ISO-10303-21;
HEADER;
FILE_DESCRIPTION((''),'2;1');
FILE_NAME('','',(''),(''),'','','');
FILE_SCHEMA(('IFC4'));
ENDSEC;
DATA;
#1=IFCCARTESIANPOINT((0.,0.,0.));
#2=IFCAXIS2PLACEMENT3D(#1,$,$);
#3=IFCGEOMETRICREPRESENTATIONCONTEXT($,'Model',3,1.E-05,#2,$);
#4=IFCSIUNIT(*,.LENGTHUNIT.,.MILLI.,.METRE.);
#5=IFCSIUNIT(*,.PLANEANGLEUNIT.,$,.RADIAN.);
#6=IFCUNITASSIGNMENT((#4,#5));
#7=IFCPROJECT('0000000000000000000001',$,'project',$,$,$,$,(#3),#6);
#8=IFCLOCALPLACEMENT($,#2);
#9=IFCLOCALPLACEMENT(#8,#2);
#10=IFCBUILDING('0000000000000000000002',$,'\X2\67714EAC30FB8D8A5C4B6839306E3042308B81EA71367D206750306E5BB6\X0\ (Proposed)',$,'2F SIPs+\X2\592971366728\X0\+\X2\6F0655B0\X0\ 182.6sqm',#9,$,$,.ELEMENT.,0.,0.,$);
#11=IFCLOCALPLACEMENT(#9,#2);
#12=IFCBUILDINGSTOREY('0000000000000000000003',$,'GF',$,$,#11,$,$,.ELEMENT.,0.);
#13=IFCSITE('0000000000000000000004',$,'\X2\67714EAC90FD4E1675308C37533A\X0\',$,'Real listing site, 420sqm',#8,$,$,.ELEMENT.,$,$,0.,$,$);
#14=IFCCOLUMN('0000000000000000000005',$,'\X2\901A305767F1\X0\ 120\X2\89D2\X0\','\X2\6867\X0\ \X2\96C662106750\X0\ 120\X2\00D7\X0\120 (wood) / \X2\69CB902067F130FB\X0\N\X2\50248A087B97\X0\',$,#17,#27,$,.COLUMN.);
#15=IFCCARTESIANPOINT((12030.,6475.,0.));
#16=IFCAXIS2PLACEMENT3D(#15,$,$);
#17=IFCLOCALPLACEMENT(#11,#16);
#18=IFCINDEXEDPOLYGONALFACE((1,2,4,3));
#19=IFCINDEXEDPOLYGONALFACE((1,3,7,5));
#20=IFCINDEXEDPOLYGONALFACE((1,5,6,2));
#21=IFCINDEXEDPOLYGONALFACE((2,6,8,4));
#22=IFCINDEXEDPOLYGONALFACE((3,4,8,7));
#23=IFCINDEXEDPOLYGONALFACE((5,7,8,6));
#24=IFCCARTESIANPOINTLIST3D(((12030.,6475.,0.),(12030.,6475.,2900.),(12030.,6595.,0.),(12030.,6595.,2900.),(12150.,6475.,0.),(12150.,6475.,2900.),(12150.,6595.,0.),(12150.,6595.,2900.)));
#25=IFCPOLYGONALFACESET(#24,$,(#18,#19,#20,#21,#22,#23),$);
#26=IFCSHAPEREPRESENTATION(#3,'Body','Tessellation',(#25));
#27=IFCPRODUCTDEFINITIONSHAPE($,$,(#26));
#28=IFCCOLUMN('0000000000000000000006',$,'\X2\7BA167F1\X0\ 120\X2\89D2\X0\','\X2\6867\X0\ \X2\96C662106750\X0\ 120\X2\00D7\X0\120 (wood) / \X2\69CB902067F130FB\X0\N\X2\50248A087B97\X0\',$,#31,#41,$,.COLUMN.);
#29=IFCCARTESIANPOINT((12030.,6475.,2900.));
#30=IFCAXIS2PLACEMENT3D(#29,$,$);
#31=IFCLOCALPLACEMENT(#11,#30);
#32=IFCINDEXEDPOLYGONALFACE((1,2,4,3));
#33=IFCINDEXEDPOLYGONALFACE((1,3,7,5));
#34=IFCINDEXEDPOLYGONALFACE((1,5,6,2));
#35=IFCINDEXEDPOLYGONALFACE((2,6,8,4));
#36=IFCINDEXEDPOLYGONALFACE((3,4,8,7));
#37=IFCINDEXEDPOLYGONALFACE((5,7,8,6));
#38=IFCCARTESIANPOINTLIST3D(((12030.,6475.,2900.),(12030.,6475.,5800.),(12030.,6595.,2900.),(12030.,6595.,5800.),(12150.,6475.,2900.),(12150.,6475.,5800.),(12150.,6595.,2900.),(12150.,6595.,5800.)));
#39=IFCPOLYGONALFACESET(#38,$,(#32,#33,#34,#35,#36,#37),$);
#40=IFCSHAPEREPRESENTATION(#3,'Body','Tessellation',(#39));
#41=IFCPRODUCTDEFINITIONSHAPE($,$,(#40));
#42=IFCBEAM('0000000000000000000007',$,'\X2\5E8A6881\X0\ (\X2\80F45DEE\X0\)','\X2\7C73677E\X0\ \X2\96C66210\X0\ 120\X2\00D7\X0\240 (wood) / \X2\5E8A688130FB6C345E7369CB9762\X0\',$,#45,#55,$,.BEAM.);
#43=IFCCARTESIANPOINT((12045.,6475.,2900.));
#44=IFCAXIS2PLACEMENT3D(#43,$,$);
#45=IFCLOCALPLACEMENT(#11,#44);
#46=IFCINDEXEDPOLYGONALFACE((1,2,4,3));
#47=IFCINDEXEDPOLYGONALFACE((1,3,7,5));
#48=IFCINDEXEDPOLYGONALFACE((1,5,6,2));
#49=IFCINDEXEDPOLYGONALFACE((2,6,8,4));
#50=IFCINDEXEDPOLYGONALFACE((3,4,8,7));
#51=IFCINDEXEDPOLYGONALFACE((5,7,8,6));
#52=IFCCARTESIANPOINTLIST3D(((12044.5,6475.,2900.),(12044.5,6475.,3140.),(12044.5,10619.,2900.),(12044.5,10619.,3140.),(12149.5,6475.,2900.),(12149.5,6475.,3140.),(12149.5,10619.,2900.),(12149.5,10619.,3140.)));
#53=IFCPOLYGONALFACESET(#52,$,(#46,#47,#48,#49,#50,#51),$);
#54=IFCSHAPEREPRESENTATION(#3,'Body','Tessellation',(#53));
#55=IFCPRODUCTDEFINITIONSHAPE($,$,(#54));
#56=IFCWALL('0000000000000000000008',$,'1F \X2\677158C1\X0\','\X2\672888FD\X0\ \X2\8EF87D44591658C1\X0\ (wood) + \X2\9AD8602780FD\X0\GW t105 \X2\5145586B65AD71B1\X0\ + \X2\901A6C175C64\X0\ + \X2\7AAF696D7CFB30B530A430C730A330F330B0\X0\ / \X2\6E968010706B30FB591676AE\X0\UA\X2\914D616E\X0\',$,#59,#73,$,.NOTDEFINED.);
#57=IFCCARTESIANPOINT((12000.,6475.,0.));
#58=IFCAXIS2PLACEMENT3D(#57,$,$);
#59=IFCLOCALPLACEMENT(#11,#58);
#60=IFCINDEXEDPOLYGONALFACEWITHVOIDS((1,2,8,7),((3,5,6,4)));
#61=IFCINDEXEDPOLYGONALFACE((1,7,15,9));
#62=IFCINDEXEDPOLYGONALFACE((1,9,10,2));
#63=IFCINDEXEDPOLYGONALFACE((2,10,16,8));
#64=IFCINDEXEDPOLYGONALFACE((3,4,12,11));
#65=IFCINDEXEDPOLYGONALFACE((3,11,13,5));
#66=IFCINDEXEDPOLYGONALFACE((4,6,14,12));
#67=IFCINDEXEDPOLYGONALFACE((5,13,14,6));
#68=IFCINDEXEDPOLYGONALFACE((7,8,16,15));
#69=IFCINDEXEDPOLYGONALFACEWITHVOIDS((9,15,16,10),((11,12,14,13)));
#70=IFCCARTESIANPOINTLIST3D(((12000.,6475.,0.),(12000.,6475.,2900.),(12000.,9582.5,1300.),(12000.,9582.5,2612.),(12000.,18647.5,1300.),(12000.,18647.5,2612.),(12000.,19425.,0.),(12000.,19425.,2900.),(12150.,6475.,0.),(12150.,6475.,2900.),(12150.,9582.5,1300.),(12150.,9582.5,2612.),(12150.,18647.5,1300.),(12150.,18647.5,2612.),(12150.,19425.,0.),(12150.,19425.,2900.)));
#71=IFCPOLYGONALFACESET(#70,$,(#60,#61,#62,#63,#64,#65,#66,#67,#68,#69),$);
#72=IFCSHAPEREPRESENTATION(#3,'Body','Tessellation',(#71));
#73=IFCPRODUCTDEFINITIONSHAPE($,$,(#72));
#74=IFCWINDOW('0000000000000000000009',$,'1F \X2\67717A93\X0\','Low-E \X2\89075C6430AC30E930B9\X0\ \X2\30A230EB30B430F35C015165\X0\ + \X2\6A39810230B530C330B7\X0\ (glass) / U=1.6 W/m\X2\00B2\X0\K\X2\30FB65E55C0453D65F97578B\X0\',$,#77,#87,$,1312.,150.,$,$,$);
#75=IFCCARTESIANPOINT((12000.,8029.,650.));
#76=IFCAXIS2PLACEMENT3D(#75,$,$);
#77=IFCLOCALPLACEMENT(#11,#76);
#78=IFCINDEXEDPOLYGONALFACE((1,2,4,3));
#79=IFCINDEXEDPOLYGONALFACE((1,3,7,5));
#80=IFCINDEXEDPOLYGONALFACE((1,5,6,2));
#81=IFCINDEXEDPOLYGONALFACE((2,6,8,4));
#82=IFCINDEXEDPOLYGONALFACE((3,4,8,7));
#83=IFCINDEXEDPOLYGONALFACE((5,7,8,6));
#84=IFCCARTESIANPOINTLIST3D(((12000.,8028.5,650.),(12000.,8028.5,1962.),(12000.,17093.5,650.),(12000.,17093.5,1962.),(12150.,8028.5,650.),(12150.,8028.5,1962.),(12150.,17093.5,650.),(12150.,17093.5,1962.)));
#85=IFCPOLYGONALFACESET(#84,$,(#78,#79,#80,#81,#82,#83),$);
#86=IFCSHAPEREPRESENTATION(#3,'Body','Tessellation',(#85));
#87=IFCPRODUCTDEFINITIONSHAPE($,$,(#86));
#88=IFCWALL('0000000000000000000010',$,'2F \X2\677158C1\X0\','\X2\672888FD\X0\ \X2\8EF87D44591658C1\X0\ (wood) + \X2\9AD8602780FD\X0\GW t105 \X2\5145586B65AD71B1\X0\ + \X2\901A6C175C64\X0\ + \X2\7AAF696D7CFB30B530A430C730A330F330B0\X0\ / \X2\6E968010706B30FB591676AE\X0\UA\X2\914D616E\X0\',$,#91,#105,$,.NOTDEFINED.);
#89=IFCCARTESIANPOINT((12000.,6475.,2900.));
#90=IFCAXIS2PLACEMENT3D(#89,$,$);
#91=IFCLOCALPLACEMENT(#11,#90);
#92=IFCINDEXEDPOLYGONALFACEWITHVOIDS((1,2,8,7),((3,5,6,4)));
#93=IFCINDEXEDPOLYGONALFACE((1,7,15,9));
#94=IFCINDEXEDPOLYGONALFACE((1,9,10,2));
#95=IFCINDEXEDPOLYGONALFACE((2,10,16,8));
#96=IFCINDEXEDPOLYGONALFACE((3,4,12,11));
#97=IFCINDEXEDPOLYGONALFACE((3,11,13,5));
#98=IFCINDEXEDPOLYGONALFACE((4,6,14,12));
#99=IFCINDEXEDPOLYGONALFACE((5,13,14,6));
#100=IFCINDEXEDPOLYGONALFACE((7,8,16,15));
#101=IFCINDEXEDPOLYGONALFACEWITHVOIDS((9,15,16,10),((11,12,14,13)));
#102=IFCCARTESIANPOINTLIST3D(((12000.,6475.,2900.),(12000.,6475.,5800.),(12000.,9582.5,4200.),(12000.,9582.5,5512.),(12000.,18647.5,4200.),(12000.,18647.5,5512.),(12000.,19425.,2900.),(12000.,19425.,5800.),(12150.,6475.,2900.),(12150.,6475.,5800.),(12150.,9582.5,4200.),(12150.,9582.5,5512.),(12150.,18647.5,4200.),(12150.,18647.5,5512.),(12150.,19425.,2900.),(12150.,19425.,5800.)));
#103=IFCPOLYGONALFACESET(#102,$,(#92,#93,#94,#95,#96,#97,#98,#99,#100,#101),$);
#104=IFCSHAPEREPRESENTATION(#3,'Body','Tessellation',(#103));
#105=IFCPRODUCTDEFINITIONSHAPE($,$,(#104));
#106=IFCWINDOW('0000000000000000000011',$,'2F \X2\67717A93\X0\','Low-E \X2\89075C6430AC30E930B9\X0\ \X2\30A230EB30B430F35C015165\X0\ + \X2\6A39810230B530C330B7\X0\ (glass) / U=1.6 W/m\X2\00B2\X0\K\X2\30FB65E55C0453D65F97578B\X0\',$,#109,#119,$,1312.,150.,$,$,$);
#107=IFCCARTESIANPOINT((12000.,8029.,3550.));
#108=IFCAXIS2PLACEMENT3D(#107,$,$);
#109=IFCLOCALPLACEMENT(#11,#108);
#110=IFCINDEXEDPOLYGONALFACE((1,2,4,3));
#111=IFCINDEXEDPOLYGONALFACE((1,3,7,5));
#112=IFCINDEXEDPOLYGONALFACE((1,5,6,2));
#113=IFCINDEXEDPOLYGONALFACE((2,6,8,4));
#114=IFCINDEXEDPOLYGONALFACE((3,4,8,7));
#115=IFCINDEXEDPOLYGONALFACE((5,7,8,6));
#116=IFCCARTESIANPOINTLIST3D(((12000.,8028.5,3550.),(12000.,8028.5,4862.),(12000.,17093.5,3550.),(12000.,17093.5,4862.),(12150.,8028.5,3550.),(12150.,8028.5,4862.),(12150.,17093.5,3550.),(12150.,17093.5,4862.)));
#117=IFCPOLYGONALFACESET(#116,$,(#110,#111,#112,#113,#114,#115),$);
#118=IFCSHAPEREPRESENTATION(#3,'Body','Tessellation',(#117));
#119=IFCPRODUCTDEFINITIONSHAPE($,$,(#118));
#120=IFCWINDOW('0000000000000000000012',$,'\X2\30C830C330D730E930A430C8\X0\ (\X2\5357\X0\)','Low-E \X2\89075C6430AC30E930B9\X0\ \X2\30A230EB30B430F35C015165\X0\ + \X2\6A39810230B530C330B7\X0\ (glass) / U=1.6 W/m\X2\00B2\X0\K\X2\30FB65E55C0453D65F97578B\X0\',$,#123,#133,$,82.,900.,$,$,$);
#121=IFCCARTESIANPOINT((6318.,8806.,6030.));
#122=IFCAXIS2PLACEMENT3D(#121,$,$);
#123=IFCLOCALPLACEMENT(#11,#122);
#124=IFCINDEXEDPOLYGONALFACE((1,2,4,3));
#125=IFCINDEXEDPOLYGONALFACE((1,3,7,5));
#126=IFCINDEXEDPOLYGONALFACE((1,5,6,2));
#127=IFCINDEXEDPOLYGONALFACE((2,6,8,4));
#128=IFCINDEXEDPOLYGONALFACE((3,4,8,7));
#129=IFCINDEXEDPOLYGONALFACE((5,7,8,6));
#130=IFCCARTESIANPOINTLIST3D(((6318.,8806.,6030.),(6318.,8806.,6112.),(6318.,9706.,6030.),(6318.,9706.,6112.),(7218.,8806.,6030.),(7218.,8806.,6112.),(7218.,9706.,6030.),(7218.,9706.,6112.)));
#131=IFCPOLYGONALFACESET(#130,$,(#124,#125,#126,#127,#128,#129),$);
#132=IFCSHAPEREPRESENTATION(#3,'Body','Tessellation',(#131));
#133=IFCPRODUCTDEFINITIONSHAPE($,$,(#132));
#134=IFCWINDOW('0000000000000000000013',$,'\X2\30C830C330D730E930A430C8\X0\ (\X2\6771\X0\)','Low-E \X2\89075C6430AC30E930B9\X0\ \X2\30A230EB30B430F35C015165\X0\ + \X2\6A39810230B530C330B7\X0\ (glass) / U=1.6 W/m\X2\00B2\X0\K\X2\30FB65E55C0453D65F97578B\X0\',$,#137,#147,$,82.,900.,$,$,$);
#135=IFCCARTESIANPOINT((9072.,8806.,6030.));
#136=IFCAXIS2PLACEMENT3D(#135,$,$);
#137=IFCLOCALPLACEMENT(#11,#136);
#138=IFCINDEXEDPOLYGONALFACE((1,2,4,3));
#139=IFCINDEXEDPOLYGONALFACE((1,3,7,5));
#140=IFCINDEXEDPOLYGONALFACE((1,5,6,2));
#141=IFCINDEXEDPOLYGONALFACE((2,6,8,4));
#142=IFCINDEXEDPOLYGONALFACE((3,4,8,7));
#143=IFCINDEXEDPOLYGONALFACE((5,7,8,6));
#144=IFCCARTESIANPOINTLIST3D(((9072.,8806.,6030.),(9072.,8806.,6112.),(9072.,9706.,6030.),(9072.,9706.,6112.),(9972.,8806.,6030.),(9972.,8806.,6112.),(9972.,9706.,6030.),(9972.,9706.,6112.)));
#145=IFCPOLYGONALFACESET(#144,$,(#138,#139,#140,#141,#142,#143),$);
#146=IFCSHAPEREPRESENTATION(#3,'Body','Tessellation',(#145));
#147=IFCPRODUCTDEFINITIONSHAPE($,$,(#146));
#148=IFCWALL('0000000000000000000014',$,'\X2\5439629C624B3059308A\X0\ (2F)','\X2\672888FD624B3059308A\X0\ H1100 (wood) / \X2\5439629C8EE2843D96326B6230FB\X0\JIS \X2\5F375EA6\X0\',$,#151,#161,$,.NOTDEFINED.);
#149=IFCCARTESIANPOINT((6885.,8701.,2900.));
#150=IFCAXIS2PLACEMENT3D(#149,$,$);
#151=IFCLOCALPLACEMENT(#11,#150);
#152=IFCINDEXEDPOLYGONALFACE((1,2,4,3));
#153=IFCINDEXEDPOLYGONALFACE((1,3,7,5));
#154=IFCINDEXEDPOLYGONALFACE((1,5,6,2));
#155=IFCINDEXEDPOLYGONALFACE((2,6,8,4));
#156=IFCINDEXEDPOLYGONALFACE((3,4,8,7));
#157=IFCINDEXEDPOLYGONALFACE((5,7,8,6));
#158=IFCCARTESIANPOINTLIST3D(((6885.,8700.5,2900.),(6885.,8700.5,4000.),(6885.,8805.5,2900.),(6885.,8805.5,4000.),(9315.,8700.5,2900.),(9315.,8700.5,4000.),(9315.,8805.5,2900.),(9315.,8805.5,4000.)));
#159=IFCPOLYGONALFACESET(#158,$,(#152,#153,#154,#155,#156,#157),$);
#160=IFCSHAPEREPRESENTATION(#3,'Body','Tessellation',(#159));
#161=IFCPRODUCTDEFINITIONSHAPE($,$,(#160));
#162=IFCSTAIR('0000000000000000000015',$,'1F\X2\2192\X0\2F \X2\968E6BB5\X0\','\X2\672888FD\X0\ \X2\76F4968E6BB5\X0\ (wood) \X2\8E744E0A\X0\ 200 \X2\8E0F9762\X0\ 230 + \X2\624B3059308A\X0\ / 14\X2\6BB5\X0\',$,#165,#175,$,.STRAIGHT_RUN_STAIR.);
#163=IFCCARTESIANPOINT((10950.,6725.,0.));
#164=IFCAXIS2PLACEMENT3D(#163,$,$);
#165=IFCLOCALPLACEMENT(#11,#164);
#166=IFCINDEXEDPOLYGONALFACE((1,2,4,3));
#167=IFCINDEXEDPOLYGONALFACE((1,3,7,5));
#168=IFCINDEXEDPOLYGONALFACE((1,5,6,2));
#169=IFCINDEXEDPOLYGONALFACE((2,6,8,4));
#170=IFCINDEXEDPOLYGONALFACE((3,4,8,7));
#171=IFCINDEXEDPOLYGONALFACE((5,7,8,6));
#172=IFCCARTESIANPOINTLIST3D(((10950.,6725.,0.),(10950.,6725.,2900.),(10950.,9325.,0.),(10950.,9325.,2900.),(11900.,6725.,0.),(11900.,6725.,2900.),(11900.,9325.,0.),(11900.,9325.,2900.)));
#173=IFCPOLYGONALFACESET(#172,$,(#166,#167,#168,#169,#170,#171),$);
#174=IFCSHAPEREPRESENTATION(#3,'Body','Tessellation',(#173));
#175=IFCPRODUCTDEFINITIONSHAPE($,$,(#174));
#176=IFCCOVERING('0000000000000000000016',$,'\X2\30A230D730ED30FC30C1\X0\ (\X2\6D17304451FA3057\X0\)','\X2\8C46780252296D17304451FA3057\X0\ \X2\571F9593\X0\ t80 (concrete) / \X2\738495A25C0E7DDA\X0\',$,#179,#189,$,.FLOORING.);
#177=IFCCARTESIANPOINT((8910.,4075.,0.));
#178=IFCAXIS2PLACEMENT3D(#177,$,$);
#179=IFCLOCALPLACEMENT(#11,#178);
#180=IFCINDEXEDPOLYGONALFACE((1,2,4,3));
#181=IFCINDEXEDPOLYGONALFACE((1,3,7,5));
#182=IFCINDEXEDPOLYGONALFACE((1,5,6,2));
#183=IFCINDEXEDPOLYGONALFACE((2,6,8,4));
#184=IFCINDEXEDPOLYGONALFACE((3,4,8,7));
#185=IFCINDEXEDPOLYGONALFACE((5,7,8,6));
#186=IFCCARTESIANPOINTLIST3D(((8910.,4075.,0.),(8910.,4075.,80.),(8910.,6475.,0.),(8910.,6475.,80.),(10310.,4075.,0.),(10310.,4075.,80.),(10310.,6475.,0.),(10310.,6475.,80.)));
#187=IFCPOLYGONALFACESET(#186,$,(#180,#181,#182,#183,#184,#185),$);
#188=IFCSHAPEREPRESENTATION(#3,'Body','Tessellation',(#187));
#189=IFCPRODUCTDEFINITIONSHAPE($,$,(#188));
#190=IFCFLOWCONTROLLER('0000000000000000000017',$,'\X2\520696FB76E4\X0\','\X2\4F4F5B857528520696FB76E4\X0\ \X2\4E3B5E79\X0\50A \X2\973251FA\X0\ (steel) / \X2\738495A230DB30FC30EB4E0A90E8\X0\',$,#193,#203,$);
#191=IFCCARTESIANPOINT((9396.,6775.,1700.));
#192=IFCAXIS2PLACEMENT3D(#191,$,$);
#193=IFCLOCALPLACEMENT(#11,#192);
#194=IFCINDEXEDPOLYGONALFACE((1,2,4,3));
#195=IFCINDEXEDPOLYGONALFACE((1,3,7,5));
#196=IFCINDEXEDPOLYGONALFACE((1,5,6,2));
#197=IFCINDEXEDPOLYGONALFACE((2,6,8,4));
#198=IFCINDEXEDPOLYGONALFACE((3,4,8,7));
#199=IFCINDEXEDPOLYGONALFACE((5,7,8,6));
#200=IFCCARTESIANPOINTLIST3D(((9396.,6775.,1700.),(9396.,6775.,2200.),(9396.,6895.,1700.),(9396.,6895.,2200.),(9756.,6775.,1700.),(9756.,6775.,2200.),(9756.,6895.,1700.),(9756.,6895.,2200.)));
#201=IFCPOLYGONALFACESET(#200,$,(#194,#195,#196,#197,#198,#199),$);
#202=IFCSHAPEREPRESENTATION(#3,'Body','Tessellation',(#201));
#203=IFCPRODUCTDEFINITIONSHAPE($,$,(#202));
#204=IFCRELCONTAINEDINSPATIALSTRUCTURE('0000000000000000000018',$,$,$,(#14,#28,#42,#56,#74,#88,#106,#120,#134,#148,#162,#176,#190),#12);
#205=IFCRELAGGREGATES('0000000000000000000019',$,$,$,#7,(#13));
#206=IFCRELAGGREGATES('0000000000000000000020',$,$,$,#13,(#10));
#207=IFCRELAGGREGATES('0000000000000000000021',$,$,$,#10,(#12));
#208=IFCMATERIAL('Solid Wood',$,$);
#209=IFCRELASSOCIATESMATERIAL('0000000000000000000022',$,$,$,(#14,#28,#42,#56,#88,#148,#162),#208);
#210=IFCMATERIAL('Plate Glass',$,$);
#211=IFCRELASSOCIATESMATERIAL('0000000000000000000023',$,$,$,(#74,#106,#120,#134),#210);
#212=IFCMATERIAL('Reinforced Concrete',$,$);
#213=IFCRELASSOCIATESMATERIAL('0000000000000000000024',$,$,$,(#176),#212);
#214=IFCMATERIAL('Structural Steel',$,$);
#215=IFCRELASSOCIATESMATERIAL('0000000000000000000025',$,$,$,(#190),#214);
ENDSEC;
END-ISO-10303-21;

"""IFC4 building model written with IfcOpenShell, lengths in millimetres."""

from ifc_helpers import new_model, si_unit, frame, frame_2d, origin, place, context, project, spatial, rectangle, extrude, material, element, fill, save


model = new_model("IFC4")

# Units and contexts
model_context = context("Model", 3, precision=1e-05, world=origin())
ifc_project = project(units=[si_unit("LENGTHUNIT", "METRE", prefix="MILLI"), si_unit("PLANEANGLEUNIT", "RADIAN")], contexts=[model_context])

# Site, building, storey
site_placement = place(None, origin())
site = spatial("IfcSite", under=ifc_project, at=site_placement, Name="東京都世田谷区", ObjectType="Real listing site, 420sqm", CompositionType="ELEMENT", RefElevation=0.0)
building_placement = place(site_placement, origin())
building = spatial("IfcBuilding", under=site, at=building_placement, Name="東京・越屋根のある自然素材の家 (Proposed)", ObjectType="2F SIPs+天然木+漆喰 182.6sqm", CompositionType="ELEMENT", ElevationOfRefHeight=0.0, ElevationOfTerrain=0.0)
storey_placement = place(building_placement, origin())
storey = spatial("IfcBuildingStorey", under=building, at=storey_placement, Name="GF", CompositionType="ELEMENT", Elevation=0.0)

# Columns
ifc_material_1 = material(Name="Solid Wood")
column_1_placement = place(storey_placement, frame((12030.0, 6475.0, 0.0)))
element("IfcColumn", 1, at=column_1_placement, inside=storey, material=ifc_material_1, Name="通し柱 120角", Description="桧 集成材 120×120 (wood) / 構造柱・N値計算", PredefinedType="COLUMN", context=model_context, shape_type="SweptSolid", body=[
    extrude(rectangle(XDim=120.0, YDim=120.0, at=frame_2d((60.0, 60.0))), frame((12030.0, 6475.0, 0.0)), (0.0, 0.0, 1.0), 2900.0),
])
column_2_placement = place(storey_placement, frame((12030.0, 6475.0, 2900.0)))
element("IfcColumn", 2, at=column_2_placement, inside=storey, material=ifc_material_1, Name="管柱 120角", Description="桧 集成材 120×120 (wood) / 構造柱・N値計算", PredefinedType="COLUMN", context=model_context, shape_type="SweptSolid", body=[
    extrude(rectangle(XDim=120.0, YDim=120.0, at=frame_2d((60.0, 60.0))), frame((12030.0, 6475.0, 2900.0)), (0.0, 0.0, 1.0), 2900.0),
])

# Beam
beam_1_placement = place(storey_placement, frame((12045.0, 6475.0, 2900.0)))
element("IfcBeam", 3, at=beam_1_placement, inside=storey, material=ifc_material_1, Name="床梁 (胴差)", Description="米松 集成 120×240 (wood) / 床梁・水平構面", PredefinedType="BEAM", context=model_context, shape_type="SweptSolid", body=[
    extrude(rectangle(XDim=105.0, YDim=4144.0, at=frame_2d((52.0, 2072.0))), frame((12045.0, 6475.0, 2900.0)), (0.0, 0.0, 1.0), 240.0),
])

# Wall, opening, window
wall_1_placement = place(storey_placement, frame((12000.0, 6475.0, 0.0)))
wall_1 = element("IfcWall", 4, at=wall_1_placement, inside=storey, material=ifc_material_1, Name="1F 東壁", Description="木製 軸組外壁 (wood) + 高性能GW t105 充填断熱 + 通気層 + 窯業系サイディング / 準耐火・外皮UA配慮", PredefinedType="NOTDEFINED", context=model_context, shape_type="SweptSolid", body=[
    extrude(rectangle(XDim=150.0, YDim=12950.0, at=frame_2d((75.0, 6475.0))), frame((12000.0, 6475.0, 0.0)), (0.0, 0.0, 1.0), 2900.0),
])
opening_1_placement = place(storey_placement, frame((12000.0, 8029.0, 650.0)))
opening_1 = element("IfcOpeningElement", 5, at=opening_1_placement, cuts=wall_1, PredefinedType="NOTDEFINED", context=model_context, shape_type="SweptSolid", body=[
    extrude(rectangle(XDim=150.0, YDim=9065.0, at=frame_2d((75.0, 4532.0))), frame((12000.0, 8029.0, 650.0)), (0.0, 0.0, 1.0), 1312.0),
])
ifc_material_2 = material(Name="Plate Glass")
window_1_placement = place(storey_placement, frame((12000.0, 8029.0, 650.0)))
window_1 = element("IfcWindow", 6, at=window_1_placement, inside=storey, material=ifc_material_2, Name="1F 東窓", Description="Low-E 複層ガラス アルゴン封入 + 樹脂サッシ (glass) / U=1.6 W/m²K・日射取得型", OverallHeight=1312.0, OverallWidth=150.0, context=model_context, shape_type="SweptSolid", body=[
    extrude(rectangle(XDim=150.0, YDim=9065.0, at=frame_2d((75.0, 4532.0))), frame((12000.0, 8029.0, 650.0)), (0.0, 0.0, 1.0), 1312.0),
])
fill(opening_1, window_1)

# Wall, opening, window
wall_2_placement = place(storey_placement, frame((12000.0, 6475.0, 2900.0)))
wall_2 = element("IfcWall", 7, at=wall_2_placement, inside=storey, material=ifc_material_1, Name="2F 東壁", Description="木製 軸組外壁 (wood) + 高性能GW t105 充填断熱 + 通気層 + 窯業系サイディング / 準耐火・外皮UA配慮", PredefinedType="NOTDEFINED", context=model_context, shape_type="SweptSolid", body=[
    extrude(rectangle(XDim=150.0, YDim=12950.0, at=frame_2d((75.0, 6475.0))), frame((12000.0, 6475.0, 2900.0)), (0.0, 0.0, 1.0), 2900.0),
])
opening_2_placement = place(storey_placement, frame((12000.0, 8029.0, 3550.0)))
opening_2 = element("IfcOpeningElement", 8, at=opening_2_placement, cuts=wall_2, PredefinedType="NOTDEFINED", context=model_context, shape_type="SweptSolid", body=[
    extrude(rectangle(XDim=150.0, YDim=9065.0, at=frame_2d((75.0, 4532.0))), frame((12000.0, 8029.0, 3550.0)), (0.0, 0.0, 1.0), 1312.0),
])
window_2_placement = place(storey_placement, frame((12000.0, 8029.0, 3550.0)))
window_2 = element("IfcWindow", 9, at=window_2_placement, inside=storey, material=ifc_material_2, Name="2F 東窓", Description="Low-E 複層ガラス アルゴン封入 + 樹脂サッシ (glass) / U=1.6 W/m²K・日射取得型", OverallHeight=1312.0, OverallWidth=150.0, context=model_context, shape_type="SweptSolid", body=[
    extrude(rectangle(XDim=150.0, YDim=9065.0, at=frame_2d((75.0, 4532.0))), frame((12000.0, 8029.0, 3550.0)), (0.0, 0.0, 1.0), 1312.0),
])
fill(opening_2, window_2)

# Windows
window_3_placement = place(storey_placement, frame((6318.0, 8806.0, 6030.0)))
element("IfcWindow", 10, at=window_3_placement, inside=storey, material=ifc_material_2, Name="トップライト (南)", Description="Low-E 複層ガラス アルゴン封入 + 樹脂サッシ (glass) / U=1.6 W/m²K・日射取得型", OverallHeight=82.0, OverallWidth=900.0, context=model_context, shape_type="SweptSolid", body=[
    extrude(rectangle(XDim=900.0, YDim=900.0, at=frame_2d((450.0, 450.0))), frame((6318.0, 8806.0, 6030.0)), (0.0, 0.0, 1.0), 82.0),
])
window_4_placement = place(storey_placement, frame((9072.0, 8806.0, 6030.0)))
element("IfcWindow", 11, at=window_4_placement, inside=storey, material=ifc_material_2, Name="トップライト (東)", Description="Low-E 複層ガラス アルゴン封入 + 樹脂サッシ (glass) / U=1.6 W/m²K・日射取得型", OverallHeight=82.0, OverallWidth=900.0, context=model_context, shape_type="SweptSolid", body=[
    extrude(rectangle(XDim=900.0, YDim=900.0, at=frame_2d((450.0, 450.0))), frame((9072.0, 8806.0, 6030.0)), (0.0, 0.0, 1.0), 82.0),
])

# Wall
wall_3_placement = place(storey_placement, frame((6885.0, 8701.0, 2900.0)))
element("IfcWall", 12, at=wall_3_placement, inside=storey, material=ifc_material_1, Name="吹抜手すり (2F)", Description="木製手すり H1100 (wood) / 吹抜転落防止・JIS 強度", PredefinedType="NOTDEFINED", context=model_context, shape_type="SweptSolid", body=[
    extrude(rectangle(XDim=2430.0, YDim=105.0, at=frame_2d((1215.0, 52.0))), frame((6885.0, 8701.0, 2900.0)), (0.0, 0.0, 1.0), 1100.0),
])

# Stair
stair_placement = place(storey_placement, frame((10950.0, 6725.0, 0.0)))
element("IfcStair", 13, at=stair_placement, inside=storey, material=ifc_material_1, Name="1F→2F 階段", Description="木製 直階段 (wood) 蹴上 200 踏面 230 + 手すり / 14段", PredefinedType="STRAIGHT_RUN_STAIR", context=model_context, shape_type="SweptSolid", body=[
    extrude(rectangle(XDim=950.0, YDim=2600.0, at=frame_2d((475.0, 1300.0))), frame((10950.0, 6725.0, 0.0)), (0.0, 0.0, 1.0), 2900.0),
])

# Covering
ifc_material_3 = material(Name="Reinforced Concrete")
covering_placement = place(storey_placement, frame((8910.0, 4075.0, 0.0)))
element("IfcCovering", 14, at=covering_placement, inside=storey, material=ifc_material_3, Name="アプローチ (洗い出し)", Description="豆砂利洗い出し 土間 t80 (concrete) / 玄関導線", PredefinedType="FLOORING", context=model_context, shape_type="SweptSolid", body=[
    extrude(rectangle(XDim=1400.0, YDim=2400.0, at=frame_2d((700.0, 1200.0))), frame((8910.0, 4075.0, 0.0)), (0.0, 0.0, 1.0), 80.0),
])

# Flow controller
ifc_material_4 = material(Name="Structural Steel")
flow_controller_placement = place(storey_placement, frame((9396.0, 6775.0, 1700.0)))
element("IfcFlowController", 15, at=flow_controller_placement, inside=storey, material=ifc_material_4, Name="分電盤", Description="住宅用分電盤 主幹50A 露出 (steel) / 玄関ホール上部", context=model_context, shape_type="SweptSolid", body=[
    extrude(rectangle(XDim=360.0, YDim=120.0, at=frame_2d((180.0, 60.0))), frame((9396.0, 6775.0, 1700.0)), (0.0, 0.0, 1.0), 500.0),
])

save(model, "model.ifc")
